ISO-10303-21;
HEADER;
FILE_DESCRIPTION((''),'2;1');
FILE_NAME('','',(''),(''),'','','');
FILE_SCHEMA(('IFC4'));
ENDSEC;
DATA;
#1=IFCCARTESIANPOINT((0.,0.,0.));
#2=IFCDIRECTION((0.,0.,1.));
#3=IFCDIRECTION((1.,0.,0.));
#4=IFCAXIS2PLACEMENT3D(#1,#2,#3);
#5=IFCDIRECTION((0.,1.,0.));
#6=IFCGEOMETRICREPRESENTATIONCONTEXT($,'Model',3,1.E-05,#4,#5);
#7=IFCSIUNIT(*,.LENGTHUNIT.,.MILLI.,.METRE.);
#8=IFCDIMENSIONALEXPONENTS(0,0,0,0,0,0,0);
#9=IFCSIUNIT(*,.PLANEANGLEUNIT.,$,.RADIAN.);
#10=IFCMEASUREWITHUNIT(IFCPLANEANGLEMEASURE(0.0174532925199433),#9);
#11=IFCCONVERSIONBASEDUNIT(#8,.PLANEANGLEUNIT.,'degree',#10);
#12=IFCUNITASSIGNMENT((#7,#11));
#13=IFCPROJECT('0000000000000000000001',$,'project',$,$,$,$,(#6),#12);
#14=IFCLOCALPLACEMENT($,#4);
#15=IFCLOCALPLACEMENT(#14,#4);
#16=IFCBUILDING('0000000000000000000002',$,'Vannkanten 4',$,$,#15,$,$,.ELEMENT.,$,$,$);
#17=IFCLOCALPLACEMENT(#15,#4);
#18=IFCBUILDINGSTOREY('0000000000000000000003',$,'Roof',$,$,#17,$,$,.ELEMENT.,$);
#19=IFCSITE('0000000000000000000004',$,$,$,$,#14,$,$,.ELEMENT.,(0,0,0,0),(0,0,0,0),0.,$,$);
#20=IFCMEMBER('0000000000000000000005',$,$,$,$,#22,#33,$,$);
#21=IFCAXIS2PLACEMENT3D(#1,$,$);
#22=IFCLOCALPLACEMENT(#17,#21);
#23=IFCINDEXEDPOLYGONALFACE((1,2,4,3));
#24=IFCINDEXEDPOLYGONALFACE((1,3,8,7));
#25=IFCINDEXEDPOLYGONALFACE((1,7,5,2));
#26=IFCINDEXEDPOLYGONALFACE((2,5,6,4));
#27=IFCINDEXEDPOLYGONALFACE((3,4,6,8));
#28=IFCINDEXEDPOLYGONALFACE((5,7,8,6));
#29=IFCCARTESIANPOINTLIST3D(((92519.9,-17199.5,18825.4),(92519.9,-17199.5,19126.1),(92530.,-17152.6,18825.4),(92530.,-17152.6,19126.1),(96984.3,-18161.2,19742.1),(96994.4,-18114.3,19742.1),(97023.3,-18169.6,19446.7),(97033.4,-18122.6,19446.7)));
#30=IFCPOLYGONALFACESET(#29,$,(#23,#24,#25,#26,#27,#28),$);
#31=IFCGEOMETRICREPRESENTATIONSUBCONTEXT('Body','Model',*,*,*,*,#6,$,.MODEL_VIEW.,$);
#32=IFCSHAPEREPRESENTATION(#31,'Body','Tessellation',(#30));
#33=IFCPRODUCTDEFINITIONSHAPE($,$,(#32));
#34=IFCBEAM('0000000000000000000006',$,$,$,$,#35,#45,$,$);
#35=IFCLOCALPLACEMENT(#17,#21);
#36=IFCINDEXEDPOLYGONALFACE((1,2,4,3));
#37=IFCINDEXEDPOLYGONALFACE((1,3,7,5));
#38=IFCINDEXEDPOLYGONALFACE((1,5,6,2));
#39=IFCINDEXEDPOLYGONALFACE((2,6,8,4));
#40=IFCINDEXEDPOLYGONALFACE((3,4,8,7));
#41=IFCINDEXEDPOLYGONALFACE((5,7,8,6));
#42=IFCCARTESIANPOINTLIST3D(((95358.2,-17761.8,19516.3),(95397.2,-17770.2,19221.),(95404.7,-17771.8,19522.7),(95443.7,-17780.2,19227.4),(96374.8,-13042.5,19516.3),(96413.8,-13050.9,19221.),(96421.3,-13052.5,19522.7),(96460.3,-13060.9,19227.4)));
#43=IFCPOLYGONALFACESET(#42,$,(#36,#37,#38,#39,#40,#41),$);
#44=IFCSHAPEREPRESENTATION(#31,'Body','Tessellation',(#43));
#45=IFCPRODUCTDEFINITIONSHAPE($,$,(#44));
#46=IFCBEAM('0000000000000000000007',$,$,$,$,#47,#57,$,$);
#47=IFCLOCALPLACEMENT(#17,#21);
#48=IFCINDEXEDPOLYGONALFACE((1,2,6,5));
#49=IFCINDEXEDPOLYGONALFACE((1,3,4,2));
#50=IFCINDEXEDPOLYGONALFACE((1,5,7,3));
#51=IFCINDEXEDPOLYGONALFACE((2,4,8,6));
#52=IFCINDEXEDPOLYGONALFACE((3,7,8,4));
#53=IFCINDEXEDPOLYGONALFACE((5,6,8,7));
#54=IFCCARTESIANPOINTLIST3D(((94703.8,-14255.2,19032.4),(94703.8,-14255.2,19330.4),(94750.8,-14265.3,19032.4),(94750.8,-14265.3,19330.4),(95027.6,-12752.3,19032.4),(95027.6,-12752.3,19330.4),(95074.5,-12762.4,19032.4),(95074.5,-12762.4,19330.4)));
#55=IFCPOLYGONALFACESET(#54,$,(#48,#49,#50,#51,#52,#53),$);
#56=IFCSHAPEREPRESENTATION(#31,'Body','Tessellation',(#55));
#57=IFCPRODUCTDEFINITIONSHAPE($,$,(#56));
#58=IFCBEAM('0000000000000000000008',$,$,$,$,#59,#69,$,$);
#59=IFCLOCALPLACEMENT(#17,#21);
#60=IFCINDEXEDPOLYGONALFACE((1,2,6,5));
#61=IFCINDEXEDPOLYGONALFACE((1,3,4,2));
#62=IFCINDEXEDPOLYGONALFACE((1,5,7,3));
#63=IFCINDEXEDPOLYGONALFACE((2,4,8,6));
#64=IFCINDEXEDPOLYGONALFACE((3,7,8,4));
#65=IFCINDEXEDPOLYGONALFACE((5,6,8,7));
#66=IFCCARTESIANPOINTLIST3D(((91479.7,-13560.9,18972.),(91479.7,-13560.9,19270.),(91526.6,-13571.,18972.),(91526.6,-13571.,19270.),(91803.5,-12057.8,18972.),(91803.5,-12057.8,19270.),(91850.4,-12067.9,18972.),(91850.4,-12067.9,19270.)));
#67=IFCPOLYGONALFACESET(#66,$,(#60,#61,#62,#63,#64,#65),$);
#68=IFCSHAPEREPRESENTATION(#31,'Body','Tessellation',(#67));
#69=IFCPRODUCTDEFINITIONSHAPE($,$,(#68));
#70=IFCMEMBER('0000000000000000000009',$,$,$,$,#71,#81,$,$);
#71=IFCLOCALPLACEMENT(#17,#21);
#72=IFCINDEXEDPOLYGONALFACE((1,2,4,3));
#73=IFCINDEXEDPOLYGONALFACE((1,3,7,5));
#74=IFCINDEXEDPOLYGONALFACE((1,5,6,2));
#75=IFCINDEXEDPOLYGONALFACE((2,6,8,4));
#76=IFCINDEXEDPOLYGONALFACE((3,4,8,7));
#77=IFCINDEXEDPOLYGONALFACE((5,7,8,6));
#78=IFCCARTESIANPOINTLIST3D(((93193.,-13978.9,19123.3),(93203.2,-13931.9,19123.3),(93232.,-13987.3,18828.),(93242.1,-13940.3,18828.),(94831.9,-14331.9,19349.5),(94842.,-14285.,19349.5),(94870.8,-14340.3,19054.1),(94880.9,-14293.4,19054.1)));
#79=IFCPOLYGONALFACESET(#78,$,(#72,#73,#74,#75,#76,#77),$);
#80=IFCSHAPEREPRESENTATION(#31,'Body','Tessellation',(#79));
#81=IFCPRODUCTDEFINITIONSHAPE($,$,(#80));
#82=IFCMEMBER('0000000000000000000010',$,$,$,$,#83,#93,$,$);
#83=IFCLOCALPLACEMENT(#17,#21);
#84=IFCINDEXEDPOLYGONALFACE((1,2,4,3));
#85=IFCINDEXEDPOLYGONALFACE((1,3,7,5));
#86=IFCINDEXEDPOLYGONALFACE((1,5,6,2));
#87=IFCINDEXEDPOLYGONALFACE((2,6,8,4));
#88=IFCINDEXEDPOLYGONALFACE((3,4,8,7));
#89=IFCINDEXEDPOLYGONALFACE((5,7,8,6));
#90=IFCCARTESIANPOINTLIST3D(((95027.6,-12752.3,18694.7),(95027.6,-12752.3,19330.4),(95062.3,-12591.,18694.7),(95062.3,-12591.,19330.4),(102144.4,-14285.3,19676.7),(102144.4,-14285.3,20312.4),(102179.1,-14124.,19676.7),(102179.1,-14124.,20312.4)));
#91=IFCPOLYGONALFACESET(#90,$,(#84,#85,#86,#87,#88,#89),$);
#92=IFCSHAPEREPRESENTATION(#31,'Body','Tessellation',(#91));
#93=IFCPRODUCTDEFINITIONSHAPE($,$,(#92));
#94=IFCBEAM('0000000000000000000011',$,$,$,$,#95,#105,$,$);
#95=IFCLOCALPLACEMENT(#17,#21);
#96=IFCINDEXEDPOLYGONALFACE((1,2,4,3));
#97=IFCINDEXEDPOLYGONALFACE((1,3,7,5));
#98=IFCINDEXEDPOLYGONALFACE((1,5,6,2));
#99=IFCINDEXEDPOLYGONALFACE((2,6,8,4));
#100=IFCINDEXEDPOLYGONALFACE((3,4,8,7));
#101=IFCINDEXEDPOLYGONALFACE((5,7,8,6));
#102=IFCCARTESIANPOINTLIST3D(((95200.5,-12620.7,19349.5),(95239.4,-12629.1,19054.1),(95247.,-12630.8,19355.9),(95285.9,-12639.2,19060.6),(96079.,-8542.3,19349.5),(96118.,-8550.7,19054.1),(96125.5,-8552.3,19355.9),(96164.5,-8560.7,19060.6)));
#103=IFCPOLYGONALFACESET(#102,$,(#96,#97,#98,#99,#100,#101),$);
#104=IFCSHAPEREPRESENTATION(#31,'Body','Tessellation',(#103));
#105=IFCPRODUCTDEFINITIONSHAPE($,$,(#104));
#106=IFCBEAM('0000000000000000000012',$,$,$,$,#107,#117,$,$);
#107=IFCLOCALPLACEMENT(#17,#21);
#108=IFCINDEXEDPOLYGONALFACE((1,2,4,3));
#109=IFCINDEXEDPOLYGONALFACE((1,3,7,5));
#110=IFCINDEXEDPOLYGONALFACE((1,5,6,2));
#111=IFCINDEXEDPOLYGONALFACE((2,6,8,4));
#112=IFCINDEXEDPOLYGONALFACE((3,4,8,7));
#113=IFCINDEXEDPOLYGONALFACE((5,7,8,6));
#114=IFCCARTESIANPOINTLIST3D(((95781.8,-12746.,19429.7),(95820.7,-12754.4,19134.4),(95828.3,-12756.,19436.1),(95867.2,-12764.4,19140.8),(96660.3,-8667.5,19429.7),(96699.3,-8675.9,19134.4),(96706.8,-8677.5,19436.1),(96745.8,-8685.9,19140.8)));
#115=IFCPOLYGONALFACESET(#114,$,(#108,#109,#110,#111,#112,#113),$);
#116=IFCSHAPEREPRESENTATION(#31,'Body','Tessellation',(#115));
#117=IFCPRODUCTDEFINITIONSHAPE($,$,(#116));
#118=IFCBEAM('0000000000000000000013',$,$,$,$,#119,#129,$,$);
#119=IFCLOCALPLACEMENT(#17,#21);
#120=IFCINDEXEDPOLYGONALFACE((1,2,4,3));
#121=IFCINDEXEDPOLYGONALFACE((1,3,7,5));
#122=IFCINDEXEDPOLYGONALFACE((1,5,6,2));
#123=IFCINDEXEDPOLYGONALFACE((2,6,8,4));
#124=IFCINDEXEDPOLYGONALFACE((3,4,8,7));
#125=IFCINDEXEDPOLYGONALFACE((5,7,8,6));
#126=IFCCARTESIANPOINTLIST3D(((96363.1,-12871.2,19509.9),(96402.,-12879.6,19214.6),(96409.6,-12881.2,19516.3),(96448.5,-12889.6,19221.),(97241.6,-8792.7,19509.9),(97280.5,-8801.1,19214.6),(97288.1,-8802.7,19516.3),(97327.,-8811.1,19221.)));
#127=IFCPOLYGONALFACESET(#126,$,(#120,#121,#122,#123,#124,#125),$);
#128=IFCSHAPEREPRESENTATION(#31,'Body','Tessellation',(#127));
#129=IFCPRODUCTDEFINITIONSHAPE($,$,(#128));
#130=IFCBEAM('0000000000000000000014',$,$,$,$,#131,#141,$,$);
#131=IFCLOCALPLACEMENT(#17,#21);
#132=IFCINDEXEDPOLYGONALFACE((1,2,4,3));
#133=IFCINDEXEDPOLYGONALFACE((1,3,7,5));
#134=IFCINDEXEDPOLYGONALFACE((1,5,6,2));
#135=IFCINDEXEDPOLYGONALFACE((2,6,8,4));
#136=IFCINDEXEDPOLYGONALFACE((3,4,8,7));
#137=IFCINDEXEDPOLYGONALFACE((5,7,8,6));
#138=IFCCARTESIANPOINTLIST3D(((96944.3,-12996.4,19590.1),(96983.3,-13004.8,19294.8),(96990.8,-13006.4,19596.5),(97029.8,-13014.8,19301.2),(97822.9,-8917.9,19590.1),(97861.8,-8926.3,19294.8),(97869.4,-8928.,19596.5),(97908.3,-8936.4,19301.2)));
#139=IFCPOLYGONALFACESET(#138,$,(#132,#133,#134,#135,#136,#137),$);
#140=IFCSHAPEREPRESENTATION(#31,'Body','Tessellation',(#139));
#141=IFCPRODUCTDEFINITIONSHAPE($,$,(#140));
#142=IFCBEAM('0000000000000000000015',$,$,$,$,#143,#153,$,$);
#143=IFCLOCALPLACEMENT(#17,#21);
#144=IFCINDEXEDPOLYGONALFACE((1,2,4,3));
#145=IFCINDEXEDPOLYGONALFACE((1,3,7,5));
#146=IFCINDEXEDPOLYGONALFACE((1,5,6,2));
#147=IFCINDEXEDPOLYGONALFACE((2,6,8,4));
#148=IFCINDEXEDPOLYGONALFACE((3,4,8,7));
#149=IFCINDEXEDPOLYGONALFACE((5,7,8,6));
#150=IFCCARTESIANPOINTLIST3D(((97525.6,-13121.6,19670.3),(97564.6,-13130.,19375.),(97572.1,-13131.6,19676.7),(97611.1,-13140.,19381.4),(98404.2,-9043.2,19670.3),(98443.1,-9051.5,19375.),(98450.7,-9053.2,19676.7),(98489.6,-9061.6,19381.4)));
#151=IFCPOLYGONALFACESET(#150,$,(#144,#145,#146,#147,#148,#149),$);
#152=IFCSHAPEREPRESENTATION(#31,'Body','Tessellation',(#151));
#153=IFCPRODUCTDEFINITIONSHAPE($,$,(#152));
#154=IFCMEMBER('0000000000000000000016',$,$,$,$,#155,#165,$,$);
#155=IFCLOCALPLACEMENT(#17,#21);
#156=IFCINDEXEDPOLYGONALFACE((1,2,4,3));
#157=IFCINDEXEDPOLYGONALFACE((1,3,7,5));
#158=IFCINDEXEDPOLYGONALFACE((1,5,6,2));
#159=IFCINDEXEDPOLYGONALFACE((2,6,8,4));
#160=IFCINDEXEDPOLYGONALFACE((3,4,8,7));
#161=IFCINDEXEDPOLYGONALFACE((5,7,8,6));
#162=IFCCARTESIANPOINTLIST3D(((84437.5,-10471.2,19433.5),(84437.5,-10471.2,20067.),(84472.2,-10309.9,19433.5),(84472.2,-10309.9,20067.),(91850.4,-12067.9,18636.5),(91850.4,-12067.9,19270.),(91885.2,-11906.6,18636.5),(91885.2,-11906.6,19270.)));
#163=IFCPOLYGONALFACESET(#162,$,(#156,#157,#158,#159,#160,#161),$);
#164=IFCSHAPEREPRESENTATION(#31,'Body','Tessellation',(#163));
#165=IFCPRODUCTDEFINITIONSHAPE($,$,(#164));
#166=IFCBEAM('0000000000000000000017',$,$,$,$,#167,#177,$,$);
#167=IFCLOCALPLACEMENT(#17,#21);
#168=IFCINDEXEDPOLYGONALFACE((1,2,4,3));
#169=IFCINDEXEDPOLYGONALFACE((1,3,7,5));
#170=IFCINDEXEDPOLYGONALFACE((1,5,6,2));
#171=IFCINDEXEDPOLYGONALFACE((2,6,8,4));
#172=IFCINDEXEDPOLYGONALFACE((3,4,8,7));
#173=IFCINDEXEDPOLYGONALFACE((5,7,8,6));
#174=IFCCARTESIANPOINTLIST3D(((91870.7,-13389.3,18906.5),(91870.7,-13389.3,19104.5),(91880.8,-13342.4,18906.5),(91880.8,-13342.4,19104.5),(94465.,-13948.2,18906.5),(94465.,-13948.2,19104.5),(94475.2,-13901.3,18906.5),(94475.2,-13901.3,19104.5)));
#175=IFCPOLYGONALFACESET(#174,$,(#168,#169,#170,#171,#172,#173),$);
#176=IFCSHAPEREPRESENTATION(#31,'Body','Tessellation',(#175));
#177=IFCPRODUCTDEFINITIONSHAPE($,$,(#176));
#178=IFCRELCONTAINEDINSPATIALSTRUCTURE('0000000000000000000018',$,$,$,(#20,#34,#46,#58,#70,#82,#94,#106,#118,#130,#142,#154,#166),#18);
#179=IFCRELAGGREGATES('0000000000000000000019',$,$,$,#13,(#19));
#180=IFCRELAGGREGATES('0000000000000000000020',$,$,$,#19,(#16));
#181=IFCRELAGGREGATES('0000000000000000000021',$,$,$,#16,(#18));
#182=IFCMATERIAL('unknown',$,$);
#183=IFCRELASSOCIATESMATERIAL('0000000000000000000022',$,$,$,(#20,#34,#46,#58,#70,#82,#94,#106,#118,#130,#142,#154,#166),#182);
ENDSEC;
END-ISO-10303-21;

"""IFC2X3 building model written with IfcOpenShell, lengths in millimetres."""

from ifc_helpers import new_model, entity, si_unit, converted_unit, direction, frame, origin_with_axes, place, context, subcontext, project, spatial, polyline, segment, composite_curve, outline, extrude, clip, halfspace, material, element, save


model = new_model("IFC2X3")

# Units and contexts
model_context = context("Model", 3, precision=1e-05, world=origin_with_axes(), true_north=direction((0.0, 1.0, 0.0)))
body_context = subcontext(model_context, "Body", "Model", "MODEL_VIEW")
ifc_project = project(units=[si_unit("LENGTHUNIT", "METRE", prefix="MILLI"), converted_unit("PLANEANGLEUNIT", "degree", entity("IfcPlaneAngleMeasure", 0.0174532925199433), si_unit("PLANEANGLEUNIT", "RADIAN"), dimensions=[0, 0, 0, 0, 0, 0, 0])], contexts=[model_context])

# Site, building, storey
site_placement = place(None, origin_with_axes())
site = spatial("IfcSite", under=ifc_project, at=site_placement, CompositionType="ELEMENT", RefLatitude=(0, 0, 0, 0), RefLongitude=(0, 0, 0, 0), RefElevation=0.0)
building_placement = place(site_placement, origin_with_axes())
building = spatial("IfcBuilding", under=site, at=building_placement, Name="Vannkanten 4", CompositionType="ELEMENT")
storey_placement = place(building_placement, origin_with_axes())
storey = spatial("IfcBuildingStorey", under=building, at=storey_placement, Name="Roof", CompositionType="ELEMENT")

# Member
ifc_material = material(Name="unknown")
member_1_placement = place(storey_placement, frame((97008.9, -18141.9, 19594.4), z_axis=(-0.968803, 0.208692, -0.133675), x_axis=(-0.210582, -0.977576, 0.0)))
element("IfcMember", 1, at=member_1_placement, inside=storey, material=ifc_material, context=body_context, shape_type="Clipping", body=[
    clip(extrude(outline(composite_curve([segment(polyline([(-24.0, -149.0), (-24.0, 149.0), (24.0, 149.0), (24.0, -149.0), (-24.0, -149.0)]), True, "CONTINUOUS")], self_intersect=False)), frame((0.0, 0.0, 0.0), z_axis=(0.0, 0.0, 1.0), x_axis=(1.0, 0.0, 0.0)), (0.0, 0.0, 1.0), 6972.6), halfspace(frame((-24.0, -149.0, 4648.4), z_axis=(0.0, -0.133675, -0.991025), x_axis=(0.0, -0.991025, 0.133675)), True)),
])

# Beams
beam_1_placement = place(storey_placement, frame((95400.9, -17771.0, 19371.8), z_axis=(0.210582, 0.977576, 0.0), x_axis=(-0.968803, 0.208692, -0.133675)))
element("IfcBeam", 2, at=beam_1_placement, inside=storey, material=ifc_material, context=body_context, shape_type="SweptSolid", body=[
    extrude(outline(composite_curve([segment(polyline([(-24.0, -149.0), (-24.0, 149.0), (24.0, 149.0), (24.0, -149.0), (-24.0, -149.0)]), True, "CONTINUOUS")], self_intersect=False)), frame((0.0, 0.0, 0.0), z_axis=(0.0, 0.0, 1.0), x_axis=(1.0, 0.0, 0.0)), (0.0, 0.0, 1.0), 4827.6),
])
beam_2_placement = place(storey_placement, frame((95051.1, -12757.3, 19181.4), z_axis=(-0.210582, -0.977576, 0.0), x_axis=(0.977576, -0.210582, 0.0)))
element("IfcBeam", 3, at=beam_2_placement, inside=storey, material=ifc_material, context=body_context, shape_type="SweptSolid", body=[
    extrude(outline(composite_curve([segment(polyline([(-24.0, -149.0), (-24.0, 149.0), (24.0, 149.0), (24.0, -149.0), (-24.0, -149.0)]), True, "CONTINUOUS")], self_intersect=False)), frame((0.0, 0.0, 0.0), z_axis=(0.0, 0.0, 1.0), x_axis=(1.0, 0.0, 0.0)), (0.0, 0.0, 1.0), 1537.4),
])
beam_3_placement = place(storey_placement, frame((91826.9, -12062.9, 19121.0), z_axis=(-0.210576, -0.977578, -0.000001), x_axis=(0.977578, -0.210576, 0.0)))
element("IfcBeam", 4, at=beam_3_placement, inside=storey, material=ifc_material, context=body_context, shape_type="SweptSolid", body=[
    extrude(outline(composite_curve([segment(polyline([(-24.0, -149.0), (-24.0, 149.0), (24.0, 149.0), (24.0, -149.0), (-24.0, -149.0)]), True, "CONTINUOUS")], self_intersect=False)), frame((0.0, 0.0, 0.0), z_axis=(0.0, 0.0, 1.0), x_axis=(1.0, 0.0, 0.0)), (0.0, 0.0, 1.0), 1537.5),
])

# Members
member_2_placement = place(storey_placement, frame((94856.4, -14312.6, 19201.8), z_axis=(-0.968803, 0.208692, -0.133675), x_axis=(-0.210582, -0.977576, 0.0)))
element("IfcMember", 5, at=member_2_placement, inside=storey, material=ifc_material, context=body_context, shape_type="SweptSolid", body=[
    extrude(outline(composite_curve([segment(polyline([(-24.0, -149.0), (-24.0, 149.0), (24.0, 149.0), (24.0, -149.0), (-24.0, -149.0)]), True, "CONTINUOUS")], self_intersect=False)), frame((0.0, 0.0, 0.0), z_axis=(0.0, 0.0, 1.0), x_axis=(1.0, 0.0, 0.0)), (0.0, 0.0, 1.0), 1691.6),
])
member_3_placement = place(storey_placement, frame((95045.0, -12671.6, 19012.6), z_axis=(0.968803, -0.208692, 0.133675), x_axis=(0.210582, 0.977576, 0.0)))
element("IfcMember", 6, at=member_3_placement, inside=storey, material=ifc_material, context=body_context, shape_type="Clipping", body=[
    clip(clip(extrude(outline(composite_curve([segment(polyline([(-82.5, 315.0), (-82.5, -315.0), (82.5, -315.0), (82.5, 315.0), (-82.5, 315.0)]), True, "CONTINUOUS")], self_intersect=False)), frame((0.0, 0.0, -3757.9), z_axis=(0.0, 0.0, 1.0), x_axis=(1.0, 0.0, 0.0)), (0.0, 0.0, 1.0), 14861.8), halfspace(frame((-82.5, 315.0, 42.5), z_axis=(0.0, -0.133675, 0.991025), x_axis=(0.0, 0.991025, 0.133675)), True)), halfspace(frame((82.5, 315.0, 7388.4), z_axis=(0.0, 0.133675, -0.991025), x_axis=(0.0, -0.991025, -0.133675)), True)),
])

# Beams
beam_4_placement = place(storey_placement, frame((95243.2, -12630.0, 19205.0), z_axis=(0.210582, 0.977576, 0.0), x_axis=(-0.968803, 0.208692, -0.133675)))
element("IfcBeam", 7, at=beam_4_placement, inside=storey, material=ifc_material, context=body_context, shape_type="SweptSolid", body=[
    extrude(outline(composite_curve([segment(polyline([(-24.0, -149.0), (-24.0, 149.0), (24.0, 149.0), (24.0, -149.0), (-24.0, -149.0)]), True, "CONTINUOUS")], self_intersect=False)), frame((0.0, 0.0, 0.0), z_axis=(0.0, 0.0, 1.0), x_axis=(1.0, 0.0, 0.0)), (0.0, 0.0, 1.0), 4172.0),
])
beam_5_placement = place(storey_placement, frame((95824.5, -12755.2, 19285.2), z_axis=(0.210582, 0.977576, 0.0), x_axis=(-0.968803, 0.208692, -0.133675)))
element("IfcBeam", 8, at=beam_5_placement, inside=storey, material=ifc_material, context=body_context, shape_type="SweptSolid", body=[
    extrude(outline(composite_curve([segment(polyline([(-24.0, -149.0), (-24.0, 149.0), (24.0, 149.0), (24.0, -149.0), (-24.0, -149.0)]), True, "CONTINUOUS")], self_intersect=False)), frame((0.0, 0.0, 0.0), z_axis=(0.0, 0.0, 1.0), x_axis=(1.0, 0.0, 0.0)), (0.0, 0.0, 1.0), 4172.0),
])
beam_6_placement = place(storey_placement, frame((96405.8, -12880.4, 19365.4), z_axis=(0.210582, 0.977576, 0.0), x_axis=(-0.968803, 0.208692, -0.133675)))
element("IfcBeam", 9, at=beam_6_placement, inside=storey, material=ifc_material, context=body_context, shape_type="SweptSolid", body=[
    extrude(outline(composite_curve([segment(polyline([(-24.0, -149.0), (-24.0, 149.0), (24.0, 149.0), (24.0, -149.0), (-24.0, -149.0)]), True, "CONTINUOUS")], self_intersect=False)), frame((0.0, 0.0, 0.0), z_axis=(0.0, 0.0, 1.0), x_axis=(1.0, 0.0, 0.0)), (0.0, 0.0, 1.0), 4172.0),
])
beam_7_placement = place(storey_placement, frame((96987.1, -13005.6, 19445.6), z_axis=(0.210582, 0.977576, 0.0), x_axis=(-0.968803, 0.208692, -0.133675)))
element("IfcBeam", 10, at=beam_7_placement, inside=storey, material=ifc_material, context=body_context, shape_type="SweptSolid", body=[
    extrude(outline(composite_curve([segment(polyline([(-24.0, -149.0), (-24.0, 149.0), (24.0, 149.0), (24.0, -149.0), (-24.0, -149.0)]), True, "CONTINUOUS")], self_intersect=False)), frame((0.0, 0.0, 0.0), z_axis=(0.0, 0.0, 1.0), x_axis=(1.0, 0.0, 0.0)), (0.0, 0.0, 1.0), 4172.0),
])
beam_8_placement = place(storey_placement, frame((97568.3, -13130.8, 19525.8), z_axis=(0.210582, 0.977576, 0.0), x_axis=(-0.968803, 0.208692, -0.133675)))
element("IfcBeam", 11, at=beam_8_placement, inside=storey, material=ifc_material, context=body_context, shape_type="SweptSolid", body=[
    extrude(outline(composite_curve([segment(polyline([(-24.0, -149.0), (-24.0, 149.0), (24.0, 149.0), (24.0, -149.0), (-24.0, -149.0)]), True, "CONTINUOUS")], self_intersect=False)), frame((0.0, 0.0, 0.0), z_axis=(0.0, 0.0, 1.0), x_axis=(1.0, 0.0, 0.0)), (0.0, 0.0, 1.0), 4172.0),
])

# Member
member_4_placement = place(storey_placement, frame((91867.8, -11987.3, 18953.3), z_axis=(-0.972224, 0.209415, 0.104528), x_axis=(-0.210568, -0.977579, 0.0)))
element("IfcMember", 12, at=member_4_placement, inside=storey, material=ifc_material, context=body_context, shape_type="Clipping", body=[
    clip(clip(extrude(outline(composite_curve([segment(polyline([(-82.5, 315.0), (-82.5, -315.0), (82.5, -315.0), (82.5, 315.0), (-82.5, 315.0)]), True, "CONTINUOUS")], self_intersect=False)), frame((0.0, 0.0, -3878.6), z_axis=(0.0, 0.0, 1.0), x_axis=(1.0, 0.0, 0.0)), (0.0, 0.0, 1.0), 15381.9), halfspace(frame((-82.5, 315.0, 33.1), z_axis=(-0.000008, -0.104528, 0.994522), x_axis=(0.0, 0.994522, 0.104528)), True)), halfspace(frame((82.5, 315.0, 7657.8), z_axis=(0.000014, 0.104528, -0.994522), x_axis=(0.0, -0.994522, -0.104528)), True)),
])

# Beam
beam_9_placement = place(storey_placement, frame((94470.1, -13924.7, 19005.5), z_axis=(-0.977576, 0.210582, 0.0), x_axis=(-0.210582, -0.977576, 0.0)))
element("IfcBeam", 13, at=beam_9_placement, inside=storey, material=ifc_material, context=body_context, shape_type="SweptSolid", body=[
    extrude(outline(composite_curve([segment(polyline([(-24.0, -99.0), (-24.0, 99.0), (24.0, 99.0), (24.0, -99.0), (-24.0, -99.0)]), True, "CONTINUOUS")], self_intersect=False)), frame((0.0, 0.0, 0.0), z_axis=(0.0, 0.0, 1.0), x_axis=(1.0, 0.0, 0.0)), (0.0, 0.0, 1.0), 2653.9),
])

save(model, "model.ifc")
